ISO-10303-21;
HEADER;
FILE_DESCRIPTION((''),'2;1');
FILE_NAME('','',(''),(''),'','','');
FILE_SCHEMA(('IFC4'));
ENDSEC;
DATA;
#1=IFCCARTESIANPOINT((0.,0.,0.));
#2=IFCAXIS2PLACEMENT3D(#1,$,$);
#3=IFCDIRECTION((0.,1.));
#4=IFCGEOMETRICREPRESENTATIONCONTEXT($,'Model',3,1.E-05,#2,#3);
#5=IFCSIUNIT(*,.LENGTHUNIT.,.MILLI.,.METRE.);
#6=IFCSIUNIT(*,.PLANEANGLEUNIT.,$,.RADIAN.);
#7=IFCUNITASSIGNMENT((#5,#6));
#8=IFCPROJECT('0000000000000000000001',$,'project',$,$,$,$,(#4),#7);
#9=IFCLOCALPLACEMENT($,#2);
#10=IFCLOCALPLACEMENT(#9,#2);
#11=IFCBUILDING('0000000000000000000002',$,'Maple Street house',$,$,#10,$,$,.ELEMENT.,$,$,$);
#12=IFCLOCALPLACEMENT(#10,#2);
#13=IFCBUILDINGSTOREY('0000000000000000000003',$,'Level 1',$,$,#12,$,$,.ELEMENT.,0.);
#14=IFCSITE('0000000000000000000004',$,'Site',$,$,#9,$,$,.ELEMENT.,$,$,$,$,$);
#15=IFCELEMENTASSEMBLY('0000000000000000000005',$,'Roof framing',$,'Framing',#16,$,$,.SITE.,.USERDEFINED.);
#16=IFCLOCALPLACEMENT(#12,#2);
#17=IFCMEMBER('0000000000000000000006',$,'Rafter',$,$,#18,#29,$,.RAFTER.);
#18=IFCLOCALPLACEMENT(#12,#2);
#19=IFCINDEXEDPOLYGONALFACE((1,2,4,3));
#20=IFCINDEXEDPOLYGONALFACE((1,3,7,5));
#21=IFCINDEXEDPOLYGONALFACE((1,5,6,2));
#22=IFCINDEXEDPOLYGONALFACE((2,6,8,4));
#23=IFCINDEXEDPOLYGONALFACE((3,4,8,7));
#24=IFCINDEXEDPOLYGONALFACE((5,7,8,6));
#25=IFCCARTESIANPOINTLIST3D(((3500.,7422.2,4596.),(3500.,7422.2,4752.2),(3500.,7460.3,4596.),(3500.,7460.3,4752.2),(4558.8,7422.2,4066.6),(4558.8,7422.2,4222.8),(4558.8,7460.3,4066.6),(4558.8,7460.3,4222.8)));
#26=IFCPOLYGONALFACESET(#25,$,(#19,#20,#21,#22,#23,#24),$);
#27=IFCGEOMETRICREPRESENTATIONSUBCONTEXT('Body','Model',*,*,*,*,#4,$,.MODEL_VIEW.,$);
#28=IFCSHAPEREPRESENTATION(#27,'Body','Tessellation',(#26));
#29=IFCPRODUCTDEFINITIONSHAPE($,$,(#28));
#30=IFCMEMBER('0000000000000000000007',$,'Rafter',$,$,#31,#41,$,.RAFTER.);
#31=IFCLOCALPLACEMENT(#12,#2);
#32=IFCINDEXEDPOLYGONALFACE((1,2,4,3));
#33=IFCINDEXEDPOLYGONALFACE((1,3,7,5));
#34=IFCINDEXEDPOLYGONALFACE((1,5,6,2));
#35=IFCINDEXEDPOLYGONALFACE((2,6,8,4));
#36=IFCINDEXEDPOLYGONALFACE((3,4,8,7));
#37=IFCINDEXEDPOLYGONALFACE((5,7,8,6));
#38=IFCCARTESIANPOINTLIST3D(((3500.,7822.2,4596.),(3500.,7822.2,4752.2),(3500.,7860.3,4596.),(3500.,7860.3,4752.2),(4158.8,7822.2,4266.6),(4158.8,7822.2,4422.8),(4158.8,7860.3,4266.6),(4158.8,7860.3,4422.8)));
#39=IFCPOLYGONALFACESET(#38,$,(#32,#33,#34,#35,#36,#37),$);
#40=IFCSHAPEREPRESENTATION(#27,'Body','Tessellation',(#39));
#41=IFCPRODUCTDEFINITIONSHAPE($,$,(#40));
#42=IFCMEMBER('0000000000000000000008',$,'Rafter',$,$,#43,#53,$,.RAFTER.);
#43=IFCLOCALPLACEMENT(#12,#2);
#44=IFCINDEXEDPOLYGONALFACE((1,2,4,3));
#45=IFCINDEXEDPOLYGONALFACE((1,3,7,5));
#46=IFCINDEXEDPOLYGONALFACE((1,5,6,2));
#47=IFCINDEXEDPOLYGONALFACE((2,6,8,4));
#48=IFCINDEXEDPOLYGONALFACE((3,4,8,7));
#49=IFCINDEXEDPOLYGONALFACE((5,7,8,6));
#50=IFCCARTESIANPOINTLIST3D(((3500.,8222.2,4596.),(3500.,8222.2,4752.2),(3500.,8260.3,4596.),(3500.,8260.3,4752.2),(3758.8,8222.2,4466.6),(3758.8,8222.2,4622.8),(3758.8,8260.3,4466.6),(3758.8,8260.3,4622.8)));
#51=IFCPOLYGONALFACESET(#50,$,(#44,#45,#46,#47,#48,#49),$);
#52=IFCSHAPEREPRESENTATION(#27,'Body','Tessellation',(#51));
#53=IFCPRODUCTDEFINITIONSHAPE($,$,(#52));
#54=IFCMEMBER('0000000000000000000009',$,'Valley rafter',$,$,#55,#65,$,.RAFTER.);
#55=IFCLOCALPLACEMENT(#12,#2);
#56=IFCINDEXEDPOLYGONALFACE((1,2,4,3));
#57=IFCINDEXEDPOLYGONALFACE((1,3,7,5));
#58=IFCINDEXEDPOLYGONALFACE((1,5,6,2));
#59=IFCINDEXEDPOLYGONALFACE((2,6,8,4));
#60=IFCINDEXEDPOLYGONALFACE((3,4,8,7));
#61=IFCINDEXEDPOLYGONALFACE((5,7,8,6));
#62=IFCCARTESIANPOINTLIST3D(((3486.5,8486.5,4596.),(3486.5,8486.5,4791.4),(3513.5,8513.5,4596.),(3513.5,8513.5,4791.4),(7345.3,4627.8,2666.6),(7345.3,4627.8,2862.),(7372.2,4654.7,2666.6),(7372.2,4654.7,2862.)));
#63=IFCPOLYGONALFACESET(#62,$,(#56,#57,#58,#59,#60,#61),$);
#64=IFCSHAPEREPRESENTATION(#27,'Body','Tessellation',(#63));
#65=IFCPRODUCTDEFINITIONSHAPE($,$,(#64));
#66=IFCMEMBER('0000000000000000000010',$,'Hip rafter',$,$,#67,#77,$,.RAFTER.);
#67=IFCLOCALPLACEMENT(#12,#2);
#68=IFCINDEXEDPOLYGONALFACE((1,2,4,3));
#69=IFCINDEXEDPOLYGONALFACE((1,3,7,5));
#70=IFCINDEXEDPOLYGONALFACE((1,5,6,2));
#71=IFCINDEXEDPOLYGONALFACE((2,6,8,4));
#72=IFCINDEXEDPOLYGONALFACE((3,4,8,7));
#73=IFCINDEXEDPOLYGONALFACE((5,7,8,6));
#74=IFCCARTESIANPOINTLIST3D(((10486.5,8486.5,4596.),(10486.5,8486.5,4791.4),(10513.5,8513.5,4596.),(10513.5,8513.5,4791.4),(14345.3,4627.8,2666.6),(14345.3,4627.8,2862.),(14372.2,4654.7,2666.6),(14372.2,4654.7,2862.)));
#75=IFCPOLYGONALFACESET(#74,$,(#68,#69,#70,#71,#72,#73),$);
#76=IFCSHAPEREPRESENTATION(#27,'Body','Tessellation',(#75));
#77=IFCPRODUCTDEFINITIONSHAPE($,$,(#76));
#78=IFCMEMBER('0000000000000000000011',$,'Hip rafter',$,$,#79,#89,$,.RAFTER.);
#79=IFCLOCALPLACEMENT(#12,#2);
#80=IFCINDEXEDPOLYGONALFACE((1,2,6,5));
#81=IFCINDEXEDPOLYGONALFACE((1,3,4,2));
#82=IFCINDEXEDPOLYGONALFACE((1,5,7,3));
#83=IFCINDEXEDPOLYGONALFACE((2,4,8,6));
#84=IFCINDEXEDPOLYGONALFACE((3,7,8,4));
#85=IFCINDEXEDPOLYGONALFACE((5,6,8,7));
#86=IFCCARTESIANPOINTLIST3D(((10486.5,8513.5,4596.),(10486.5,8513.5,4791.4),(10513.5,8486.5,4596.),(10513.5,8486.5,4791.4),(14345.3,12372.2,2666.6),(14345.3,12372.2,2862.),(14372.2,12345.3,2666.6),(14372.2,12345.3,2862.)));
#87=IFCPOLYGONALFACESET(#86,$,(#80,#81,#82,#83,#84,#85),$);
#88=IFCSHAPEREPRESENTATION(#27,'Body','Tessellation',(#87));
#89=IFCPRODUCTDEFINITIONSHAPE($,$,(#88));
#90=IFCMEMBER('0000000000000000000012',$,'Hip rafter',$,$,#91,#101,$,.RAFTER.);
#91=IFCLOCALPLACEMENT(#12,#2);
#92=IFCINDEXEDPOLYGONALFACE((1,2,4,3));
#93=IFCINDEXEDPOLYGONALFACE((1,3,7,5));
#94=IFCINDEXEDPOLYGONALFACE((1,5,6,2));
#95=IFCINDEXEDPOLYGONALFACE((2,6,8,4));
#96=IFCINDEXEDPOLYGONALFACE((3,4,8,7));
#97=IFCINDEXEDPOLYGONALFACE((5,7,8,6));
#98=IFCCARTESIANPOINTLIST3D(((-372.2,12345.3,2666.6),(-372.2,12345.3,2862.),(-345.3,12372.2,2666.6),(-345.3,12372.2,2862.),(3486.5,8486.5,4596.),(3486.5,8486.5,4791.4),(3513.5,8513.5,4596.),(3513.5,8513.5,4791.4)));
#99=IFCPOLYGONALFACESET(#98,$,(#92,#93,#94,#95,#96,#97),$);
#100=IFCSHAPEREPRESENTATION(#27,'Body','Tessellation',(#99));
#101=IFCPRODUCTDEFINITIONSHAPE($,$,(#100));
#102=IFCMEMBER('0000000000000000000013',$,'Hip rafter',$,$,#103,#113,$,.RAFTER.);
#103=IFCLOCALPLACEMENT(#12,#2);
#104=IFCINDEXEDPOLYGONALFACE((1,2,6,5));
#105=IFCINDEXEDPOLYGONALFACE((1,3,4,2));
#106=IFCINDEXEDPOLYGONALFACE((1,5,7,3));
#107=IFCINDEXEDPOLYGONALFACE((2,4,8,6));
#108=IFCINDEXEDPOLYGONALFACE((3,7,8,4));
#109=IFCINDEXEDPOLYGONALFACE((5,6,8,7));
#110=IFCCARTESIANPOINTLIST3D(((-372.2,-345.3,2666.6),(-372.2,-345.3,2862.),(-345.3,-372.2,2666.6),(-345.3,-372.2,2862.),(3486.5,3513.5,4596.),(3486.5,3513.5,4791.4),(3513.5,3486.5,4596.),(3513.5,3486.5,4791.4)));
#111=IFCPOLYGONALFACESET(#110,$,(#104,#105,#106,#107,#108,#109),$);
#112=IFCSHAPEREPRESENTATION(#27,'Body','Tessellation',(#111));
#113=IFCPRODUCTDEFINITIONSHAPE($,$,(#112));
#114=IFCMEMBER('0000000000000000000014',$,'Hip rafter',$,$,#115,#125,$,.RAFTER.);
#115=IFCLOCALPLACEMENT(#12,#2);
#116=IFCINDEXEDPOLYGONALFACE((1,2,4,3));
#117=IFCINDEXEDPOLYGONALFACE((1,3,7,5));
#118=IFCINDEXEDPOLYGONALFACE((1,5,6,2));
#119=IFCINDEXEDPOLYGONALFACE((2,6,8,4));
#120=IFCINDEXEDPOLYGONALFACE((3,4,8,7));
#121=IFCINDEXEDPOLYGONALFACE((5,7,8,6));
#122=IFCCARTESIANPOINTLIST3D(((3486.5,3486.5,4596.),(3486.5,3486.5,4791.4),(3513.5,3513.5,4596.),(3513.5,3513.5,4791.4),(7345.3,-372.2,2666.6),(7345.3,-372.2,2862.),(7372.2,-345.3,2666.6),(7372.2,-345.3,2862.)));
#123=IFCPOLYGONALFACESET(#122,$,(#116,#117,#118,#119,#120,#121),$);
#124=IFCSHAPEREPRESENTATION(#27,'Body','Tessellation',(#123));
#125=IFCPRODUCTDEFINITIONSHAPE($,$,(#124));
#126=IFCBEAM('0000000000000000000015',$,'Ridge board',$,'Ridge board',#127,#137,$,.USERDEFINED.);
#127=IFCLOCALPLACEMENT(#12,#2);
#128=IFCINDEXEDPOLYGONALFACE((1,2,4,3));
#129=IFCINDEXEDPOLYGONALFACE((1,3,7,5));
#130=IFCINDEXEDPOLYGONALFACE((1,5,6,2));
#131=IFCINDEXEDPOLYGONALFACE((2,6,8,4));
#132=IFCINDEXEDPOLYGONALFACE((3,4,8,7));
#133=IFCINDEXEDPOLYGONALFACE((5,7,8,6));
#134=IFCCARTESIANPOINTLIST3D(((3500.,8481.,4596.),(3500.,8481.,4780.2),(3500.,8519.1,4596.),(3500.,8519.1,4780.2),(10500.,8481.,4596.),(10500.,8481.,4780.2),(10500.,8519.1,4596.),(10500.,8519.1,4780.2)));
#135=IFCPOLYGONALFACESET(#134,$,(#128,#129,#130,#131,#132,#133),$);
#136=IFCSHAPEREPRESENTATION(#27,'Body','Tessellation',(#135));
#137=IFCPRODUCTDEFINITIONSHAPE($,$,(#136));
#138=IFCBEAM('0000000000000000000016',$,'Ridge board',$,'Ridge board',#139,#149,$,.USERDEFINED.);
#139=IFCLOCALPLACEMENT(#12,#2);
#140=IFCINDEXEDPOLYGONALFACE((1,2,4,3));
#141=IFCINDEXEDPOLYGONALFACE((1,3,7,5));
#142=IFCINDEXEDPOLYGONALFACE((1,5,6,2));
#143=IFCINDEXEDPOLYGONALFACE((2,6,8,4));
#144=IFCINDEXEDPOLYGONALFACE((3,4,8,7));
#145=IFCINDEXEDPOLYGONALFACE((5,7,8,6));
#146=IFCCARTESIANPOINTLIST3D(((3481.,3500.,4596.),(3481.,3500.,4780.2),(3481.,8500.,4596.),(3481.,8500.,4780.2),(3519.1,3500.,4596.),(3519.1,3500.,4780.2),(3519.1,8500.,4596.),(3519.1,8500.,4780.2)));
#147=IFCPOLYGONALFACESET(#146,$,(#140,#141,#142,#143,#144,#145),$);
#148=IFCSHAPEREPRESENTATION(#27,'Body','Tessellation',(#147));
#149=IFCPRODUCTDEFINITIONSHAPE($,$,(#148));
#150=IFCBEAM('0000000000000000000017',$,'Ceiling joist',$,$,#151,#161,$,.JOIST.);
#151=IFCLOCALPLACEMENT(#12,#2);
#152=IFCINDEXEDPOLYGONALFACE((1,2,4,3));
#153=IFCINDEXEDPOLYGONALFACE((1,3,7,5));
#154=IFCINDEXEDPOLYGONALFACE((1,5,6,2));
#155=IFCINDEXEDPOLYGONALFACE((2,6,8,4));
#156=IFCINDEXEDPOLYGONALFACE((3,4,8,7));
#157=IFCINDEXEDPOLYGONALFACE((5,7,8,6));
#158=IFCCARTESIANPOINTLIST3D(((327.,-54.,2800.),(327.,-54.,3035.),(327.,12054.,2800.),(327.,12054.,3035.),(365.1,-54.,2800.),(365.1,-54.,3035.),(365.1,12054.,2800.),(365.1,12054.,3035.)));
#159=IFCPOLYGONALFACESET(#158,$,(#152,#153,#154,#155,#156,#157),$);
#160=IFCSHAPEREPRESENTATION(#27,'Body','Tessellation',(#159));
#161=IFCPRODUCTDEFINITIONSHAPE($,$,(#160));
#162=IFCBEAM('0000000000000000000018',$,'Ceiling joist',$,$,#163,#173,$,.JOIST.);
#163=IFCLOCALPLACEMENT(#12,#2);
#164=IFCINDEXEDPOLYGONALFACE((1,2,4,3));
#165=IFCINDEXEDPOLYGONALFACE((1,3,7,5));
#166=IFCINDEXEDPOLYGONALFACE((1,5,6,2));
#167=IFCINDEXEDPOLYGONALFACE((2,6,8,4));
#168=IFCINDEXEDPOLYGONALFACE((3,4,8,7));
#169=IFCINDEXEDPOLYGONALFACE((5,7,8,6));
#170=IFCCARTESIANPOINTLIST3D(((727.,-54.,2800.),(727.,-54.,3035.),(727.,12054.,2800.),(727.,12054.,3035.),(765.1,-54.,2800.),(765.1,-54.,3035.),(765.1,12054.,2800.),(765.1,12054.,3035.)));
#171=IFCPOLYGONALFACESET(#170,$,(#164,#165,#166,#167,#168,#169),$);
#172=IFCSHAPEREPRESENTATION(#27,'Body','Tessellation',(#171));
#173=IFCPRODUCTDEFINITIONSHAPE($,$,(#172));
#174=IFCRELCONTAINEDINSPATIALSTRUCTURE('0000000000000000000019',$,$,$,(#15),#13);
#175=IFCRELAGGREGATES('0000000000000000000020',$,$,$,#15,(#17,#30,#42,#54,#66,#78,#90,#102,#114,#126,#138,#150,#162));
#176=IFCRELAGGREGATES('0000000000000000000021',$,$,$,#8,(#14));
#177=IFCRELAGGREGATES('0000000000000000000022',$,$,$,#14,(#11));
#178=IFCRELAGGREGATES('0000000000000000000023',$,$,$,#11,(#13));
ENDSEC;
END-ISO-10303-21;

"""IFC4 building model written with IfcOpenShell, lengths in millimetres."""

from ifc_helpers import new_model, si_unit, direction, frame, origin, origin_with_axes, place, context, subcontext, project, spatial, polyline, outline, extrude, element, aggregate, save


model = new_model("IFC4")

# Units and contexts
model_context = context("Model", 3, precision=1e-05, world=origin(), true_north=direction((0.0, 1.0)))
body_context = subcontext(model_context, "Body", "Model", "MODEL_VIEW")
ifc_project = project(units=[si_unit("LENGTHUNIT", "METRE", prefix="MILLI"), si_unit("PLANEANGLEUNIT", "RADIAN")], contexts=[model_context])

# Site, building, storey
site_placement = place(None, origin())
site = spatial("IfcSite", under=ifc_project, at=site_placement, Name="Site", CompositionType="ELEMENT")
building_placement = place(site_placement, origin())
building = spatial("IfcBuilding", under=site, at=building_placement, Name="Maple Street house", CompositionType="ELEMENT")
storey_placement = place(building_placement, origin())
storey = spatial("IfcBuildingStorey", under=building, at=storey_placement, Name="Level 1", CompositionType="ELEMENT", Elevation=0.0)

# Element assembly, members, beams
assembly_placement = place(storey_placement, origin_with_axes())
assembly = element("IfcElementAssembly", 1, at=assembly_placement, inside=storey, Name="Roof framing", ObjectType="Framing", AssemblyPlace="SITE", PredefinedType="USERDEFINED")
member_1_placement = place(storey_placement, origin_with_axes())
member_1 = element("IfcMember", 2, at=member_1_placement, Name="Rafter", PredefinedType="RAFTER", context=body_context, shape_type="SweptSolid", body=[
    extrude(outline(polyline([(0.0, 0.0), (38.1, 0.0), (38.1, 156.2), (0.0, 156.2), (0.0, 0.0)])), frame((4558.8, 7460.3, 4066.7), z_axis=(-1.0, 0.0, 0.0), x_axis=(0.0, -1.0, 0.0)), (0.0, 0.447214, 0.894427), 1183.7),
])
member_2_placement = place(storey_placement, origin_with_axes())
member_2 = element("IfcMember", 3, at=member_2_placement, Name="Rafter", PredefinedType="RAFTER", context=body_context, shape_type="SweptSolid", body=[
    extrude(outline(polyline([(0.0, 0.0), (38.1, 0.0), (38.1, 156.2), (0.0, 156.2), (0.0, 0.0)])), frame((4158.8, 7860.3, 4266.6), z_axis=(-1.0, 0.0, 0.0), x_axis=(0.0, -1.0, 0.0)), (0.0, 0.447214, 0.894427), 736.5),
])
member_3_placement = place(storey_placement, origin_with_axes())
member_3 = element("IfcMember", 4, at=member_3_placement, Name="Rafter", PredefinedType="RAFTER", context=body_context, shape_type="SweptSolid", body=[
    extrude(outline(polyline([(0.0, 0.0), (38.1, 0.0), (38.1, 156.2), (0.0, 156.2), (0.0, 0.0)])), frame((3758.8, 8260.3, 4466.6), z_axis=(-1.0, 0.0, 0.0), x_axis=(0.0, -1.0, 0.0)), (0.0, 0.447214, 0.894427), 289.3),
])
member_4_placement = place(storey_placement, origin_with_axes())
member_4 = element("IfcMember", 5, at=member_4_placement, Name="Valley rafter", PredefinedType="RAFTER", context=body_context, shape_type="SweptSolid", body=[
    extrude(outline(polyline([(0.0, 0.0), (38.1, 0.0), (38.1, 195.3), (0.0, 195.3), (0.0, 0.0)])), frame((7372.2, 4654.7, 2666.7), z_axis=(-0.707107, 0.707107, 0.0), x_axis=(-0.707107, -0.707107, 0.0)), (0.0, 0.333333, 0.942809), 5788.2),
])
member_5_placement = place(storey_placement, origin_with_axes())
member_5 = element("IfcMember", 6, at=member_5_placement, Name="Hip rafter", PredefinedType="RAFTER", context=body_context, shape_type="SweptSolid", body=[
    extrude(outline(polyline([(0.0, 0.0), (38.1, 0.0), (38.1, 195.3), (0.0, 195.3), (0.0, 0.0)])), frame((14372.2, 4654.7, 2666.7), z_axis=(-0.707107, 0.707107, 0.0), x_axis=(-0.707107, -0.707107, 0.0)), (0.0, 0.333333, 0.942809), 5788.2),
])
member_6_placement = place(storey_placement, origin_with_axes())
member_6 = element("IfcMember", 7, at=member_6_placement, Name="Hip rafter", PredefinedType="RAFTER", context=body_context, shape_type="SweptSolid", body=[
    extrude(outline(polyline([(0.0, 0.0), (38.1, 0.0), (38.1, 195.3), (0.0, 195.3), (0.0, 0.0)])), frame((14345.3, 12372.2, 2666.7), z_axis=(-0.707107, -0.707107, 0.0), x_axis=(0.707107, -0.707107, 0.0)), (0.0, 0.333333, 0.942809), 5788.2),
])
member_7_placement = place(storey_placement, origin_with_axes())
member_7 = element("IfcMember", 8, at=member_7_placement, Name="Hip rafter", PredefinedType="RAFTER", context=body_context, shape_type="SweptSolid", body=[
    extrude(outline(polyline([(0.0, 0.0), (38.1, 0.0), (38.1, 195.3), (0.0, 195.3), (0.0, 0.0)])), frame((-372.2, 12345.3, 2666.7), z_axis=(0.707107, -0.707107, 0.0), x_axis=(0.707107, 0.707107, 0.0)), (0.0, 0.333333, 0.942809), 5788.2),
])
member_8_placement = place(storey_placement, origin_with_axes())
member_8 = element("IfcMember", 9, at=member_8_placement, Name="Hip rafter", PredefinedType="RAFTER", context=body_context, shape_type="SweptSolid", body=[
    extrude(outline(polyline([(0.0, 0.0), (38.1, 0.0), (38.1, 195.3), (0.0, 195.3), (0.0, 0.0)])), frame((-345.3, -372.2, 2666.7), z_axis=(0.707107, 0.707107, 0.0), x_axis=(-0.707107, 0.707107, 0.0)), (0.0, 0.333333, 0.942809), 5788.2),
])
member_9_placement = place(storey_placement, origin_with_axes())
member_9 = element("IfcMember", 10, at=member_9_placement, Name="Hip rafter", PredefinedType="RAFTER", context=body_context, shape_type="SweptSolid", body=[
    extrude(outline(polyline([(0.0, 0.0), (38.1, 0.0), (38.1, 195.3), (0.0, 195.3), (0.0, 0.0)])), frame((7372.2, -345.3, 2666.7), z_axis=(-0.707107, 0.707107, 0.0), x_axis=(-0.707107, -0.707107, 0.0)), (0.0, 0.333333, 0.942809), 5788.2),
])
beam_1_placement = place(storey_placement, origin_with_axes())
beam_1 = element("IfcBeam", 11, at=beam_1_placement, Name="Ridge board", ObjectType="Ridge board", PredefinedType="USERDEFINED", context=body_context, shape_type="SweptSolid", body=[
    extrude(outline(polyline([(0.0, 0.0), (38.1, 0.0), (38.1, 184.2), (0.0, 184.2), (0.0, 0.0)])), frame((3500.0, 8481.0, 4596.0), z_axis=(1.0, 0.0, 0.0), x_axis=(0.0, 1.0, 0.0)), (0.0, 0.0, 1.0), 7000.0),
])
beam_2_placement = place(storey_placement, origin_with_axes())
beam_2 = element("IfcBeam", 12, at=beam_2_placement, Name="Ridge board", ObjectType="Ridge board", PredefinedType="USERDEFINED", context=body_context, shape_type="SweptSolid", body=[
    extrude(outline(polyline([(0.0, 0.0), (38.1, 0.0), (38.1, 184.2), (0.0, 184.2), (0.0, 0.0)])), frame((3481.0, 8500.0, 4596.0), z_axis=(0.0, -1.0, 0.0), x_axis=(1.0, 0.0, 0.0)), (0.0, 0.0, 1.0), 5000.0),
])
beam_3_placement = place(storey_placement, origin_with_axes())
beam_3 = element("IfcBeam", 13, at=beam_3_placement, Name="Ceiling joist", PredefinedType="JOIST", context=body_context, shape_type="SweptSolid", body=[
    extrude(outline(polyline([(0.0, 0.0), (38.1, 0.0), (38.1, 234.9), (0.0, 234.9), (0.0, 0.0)])), frame((327.0, 12054.0, 2800.0), z_axis=(0.0, -1.0, 0.0), x_axis=(1.0, 0.0, 0.0)), (0.0, 0.0, 1.0), 12108.0),
])
beam_4_placement = place(storey_placement, origin_with_axes())
beam_4 = element("IfcBeam", 14, at=beam_4_placement, Name="Ceiling joist", PredefinedType="JOIST", context=body_context, shape_type="SweptSolid", body=[
    extrude(outline(polyline([(0.0, 0.0), (38.1, 0.0), (38.1, 234.9), (0.0, 234.9), (0.0, 0.0)])), frame((727.0, 12054.0, 2800.0), z_axis=(0.0, -1.0, 0.0), x_axis=(1.0, 0.0, 0.0)), (0.0, 0.0, 1.0), 12108.0),
])
aggregate(assembly, [member_1, member_2, member_3, member_4, member_5, member_6, member_7, member_8, member_9, beam_1, beam_2, beam_3, beam_4])

save(model, "model.ifc")
